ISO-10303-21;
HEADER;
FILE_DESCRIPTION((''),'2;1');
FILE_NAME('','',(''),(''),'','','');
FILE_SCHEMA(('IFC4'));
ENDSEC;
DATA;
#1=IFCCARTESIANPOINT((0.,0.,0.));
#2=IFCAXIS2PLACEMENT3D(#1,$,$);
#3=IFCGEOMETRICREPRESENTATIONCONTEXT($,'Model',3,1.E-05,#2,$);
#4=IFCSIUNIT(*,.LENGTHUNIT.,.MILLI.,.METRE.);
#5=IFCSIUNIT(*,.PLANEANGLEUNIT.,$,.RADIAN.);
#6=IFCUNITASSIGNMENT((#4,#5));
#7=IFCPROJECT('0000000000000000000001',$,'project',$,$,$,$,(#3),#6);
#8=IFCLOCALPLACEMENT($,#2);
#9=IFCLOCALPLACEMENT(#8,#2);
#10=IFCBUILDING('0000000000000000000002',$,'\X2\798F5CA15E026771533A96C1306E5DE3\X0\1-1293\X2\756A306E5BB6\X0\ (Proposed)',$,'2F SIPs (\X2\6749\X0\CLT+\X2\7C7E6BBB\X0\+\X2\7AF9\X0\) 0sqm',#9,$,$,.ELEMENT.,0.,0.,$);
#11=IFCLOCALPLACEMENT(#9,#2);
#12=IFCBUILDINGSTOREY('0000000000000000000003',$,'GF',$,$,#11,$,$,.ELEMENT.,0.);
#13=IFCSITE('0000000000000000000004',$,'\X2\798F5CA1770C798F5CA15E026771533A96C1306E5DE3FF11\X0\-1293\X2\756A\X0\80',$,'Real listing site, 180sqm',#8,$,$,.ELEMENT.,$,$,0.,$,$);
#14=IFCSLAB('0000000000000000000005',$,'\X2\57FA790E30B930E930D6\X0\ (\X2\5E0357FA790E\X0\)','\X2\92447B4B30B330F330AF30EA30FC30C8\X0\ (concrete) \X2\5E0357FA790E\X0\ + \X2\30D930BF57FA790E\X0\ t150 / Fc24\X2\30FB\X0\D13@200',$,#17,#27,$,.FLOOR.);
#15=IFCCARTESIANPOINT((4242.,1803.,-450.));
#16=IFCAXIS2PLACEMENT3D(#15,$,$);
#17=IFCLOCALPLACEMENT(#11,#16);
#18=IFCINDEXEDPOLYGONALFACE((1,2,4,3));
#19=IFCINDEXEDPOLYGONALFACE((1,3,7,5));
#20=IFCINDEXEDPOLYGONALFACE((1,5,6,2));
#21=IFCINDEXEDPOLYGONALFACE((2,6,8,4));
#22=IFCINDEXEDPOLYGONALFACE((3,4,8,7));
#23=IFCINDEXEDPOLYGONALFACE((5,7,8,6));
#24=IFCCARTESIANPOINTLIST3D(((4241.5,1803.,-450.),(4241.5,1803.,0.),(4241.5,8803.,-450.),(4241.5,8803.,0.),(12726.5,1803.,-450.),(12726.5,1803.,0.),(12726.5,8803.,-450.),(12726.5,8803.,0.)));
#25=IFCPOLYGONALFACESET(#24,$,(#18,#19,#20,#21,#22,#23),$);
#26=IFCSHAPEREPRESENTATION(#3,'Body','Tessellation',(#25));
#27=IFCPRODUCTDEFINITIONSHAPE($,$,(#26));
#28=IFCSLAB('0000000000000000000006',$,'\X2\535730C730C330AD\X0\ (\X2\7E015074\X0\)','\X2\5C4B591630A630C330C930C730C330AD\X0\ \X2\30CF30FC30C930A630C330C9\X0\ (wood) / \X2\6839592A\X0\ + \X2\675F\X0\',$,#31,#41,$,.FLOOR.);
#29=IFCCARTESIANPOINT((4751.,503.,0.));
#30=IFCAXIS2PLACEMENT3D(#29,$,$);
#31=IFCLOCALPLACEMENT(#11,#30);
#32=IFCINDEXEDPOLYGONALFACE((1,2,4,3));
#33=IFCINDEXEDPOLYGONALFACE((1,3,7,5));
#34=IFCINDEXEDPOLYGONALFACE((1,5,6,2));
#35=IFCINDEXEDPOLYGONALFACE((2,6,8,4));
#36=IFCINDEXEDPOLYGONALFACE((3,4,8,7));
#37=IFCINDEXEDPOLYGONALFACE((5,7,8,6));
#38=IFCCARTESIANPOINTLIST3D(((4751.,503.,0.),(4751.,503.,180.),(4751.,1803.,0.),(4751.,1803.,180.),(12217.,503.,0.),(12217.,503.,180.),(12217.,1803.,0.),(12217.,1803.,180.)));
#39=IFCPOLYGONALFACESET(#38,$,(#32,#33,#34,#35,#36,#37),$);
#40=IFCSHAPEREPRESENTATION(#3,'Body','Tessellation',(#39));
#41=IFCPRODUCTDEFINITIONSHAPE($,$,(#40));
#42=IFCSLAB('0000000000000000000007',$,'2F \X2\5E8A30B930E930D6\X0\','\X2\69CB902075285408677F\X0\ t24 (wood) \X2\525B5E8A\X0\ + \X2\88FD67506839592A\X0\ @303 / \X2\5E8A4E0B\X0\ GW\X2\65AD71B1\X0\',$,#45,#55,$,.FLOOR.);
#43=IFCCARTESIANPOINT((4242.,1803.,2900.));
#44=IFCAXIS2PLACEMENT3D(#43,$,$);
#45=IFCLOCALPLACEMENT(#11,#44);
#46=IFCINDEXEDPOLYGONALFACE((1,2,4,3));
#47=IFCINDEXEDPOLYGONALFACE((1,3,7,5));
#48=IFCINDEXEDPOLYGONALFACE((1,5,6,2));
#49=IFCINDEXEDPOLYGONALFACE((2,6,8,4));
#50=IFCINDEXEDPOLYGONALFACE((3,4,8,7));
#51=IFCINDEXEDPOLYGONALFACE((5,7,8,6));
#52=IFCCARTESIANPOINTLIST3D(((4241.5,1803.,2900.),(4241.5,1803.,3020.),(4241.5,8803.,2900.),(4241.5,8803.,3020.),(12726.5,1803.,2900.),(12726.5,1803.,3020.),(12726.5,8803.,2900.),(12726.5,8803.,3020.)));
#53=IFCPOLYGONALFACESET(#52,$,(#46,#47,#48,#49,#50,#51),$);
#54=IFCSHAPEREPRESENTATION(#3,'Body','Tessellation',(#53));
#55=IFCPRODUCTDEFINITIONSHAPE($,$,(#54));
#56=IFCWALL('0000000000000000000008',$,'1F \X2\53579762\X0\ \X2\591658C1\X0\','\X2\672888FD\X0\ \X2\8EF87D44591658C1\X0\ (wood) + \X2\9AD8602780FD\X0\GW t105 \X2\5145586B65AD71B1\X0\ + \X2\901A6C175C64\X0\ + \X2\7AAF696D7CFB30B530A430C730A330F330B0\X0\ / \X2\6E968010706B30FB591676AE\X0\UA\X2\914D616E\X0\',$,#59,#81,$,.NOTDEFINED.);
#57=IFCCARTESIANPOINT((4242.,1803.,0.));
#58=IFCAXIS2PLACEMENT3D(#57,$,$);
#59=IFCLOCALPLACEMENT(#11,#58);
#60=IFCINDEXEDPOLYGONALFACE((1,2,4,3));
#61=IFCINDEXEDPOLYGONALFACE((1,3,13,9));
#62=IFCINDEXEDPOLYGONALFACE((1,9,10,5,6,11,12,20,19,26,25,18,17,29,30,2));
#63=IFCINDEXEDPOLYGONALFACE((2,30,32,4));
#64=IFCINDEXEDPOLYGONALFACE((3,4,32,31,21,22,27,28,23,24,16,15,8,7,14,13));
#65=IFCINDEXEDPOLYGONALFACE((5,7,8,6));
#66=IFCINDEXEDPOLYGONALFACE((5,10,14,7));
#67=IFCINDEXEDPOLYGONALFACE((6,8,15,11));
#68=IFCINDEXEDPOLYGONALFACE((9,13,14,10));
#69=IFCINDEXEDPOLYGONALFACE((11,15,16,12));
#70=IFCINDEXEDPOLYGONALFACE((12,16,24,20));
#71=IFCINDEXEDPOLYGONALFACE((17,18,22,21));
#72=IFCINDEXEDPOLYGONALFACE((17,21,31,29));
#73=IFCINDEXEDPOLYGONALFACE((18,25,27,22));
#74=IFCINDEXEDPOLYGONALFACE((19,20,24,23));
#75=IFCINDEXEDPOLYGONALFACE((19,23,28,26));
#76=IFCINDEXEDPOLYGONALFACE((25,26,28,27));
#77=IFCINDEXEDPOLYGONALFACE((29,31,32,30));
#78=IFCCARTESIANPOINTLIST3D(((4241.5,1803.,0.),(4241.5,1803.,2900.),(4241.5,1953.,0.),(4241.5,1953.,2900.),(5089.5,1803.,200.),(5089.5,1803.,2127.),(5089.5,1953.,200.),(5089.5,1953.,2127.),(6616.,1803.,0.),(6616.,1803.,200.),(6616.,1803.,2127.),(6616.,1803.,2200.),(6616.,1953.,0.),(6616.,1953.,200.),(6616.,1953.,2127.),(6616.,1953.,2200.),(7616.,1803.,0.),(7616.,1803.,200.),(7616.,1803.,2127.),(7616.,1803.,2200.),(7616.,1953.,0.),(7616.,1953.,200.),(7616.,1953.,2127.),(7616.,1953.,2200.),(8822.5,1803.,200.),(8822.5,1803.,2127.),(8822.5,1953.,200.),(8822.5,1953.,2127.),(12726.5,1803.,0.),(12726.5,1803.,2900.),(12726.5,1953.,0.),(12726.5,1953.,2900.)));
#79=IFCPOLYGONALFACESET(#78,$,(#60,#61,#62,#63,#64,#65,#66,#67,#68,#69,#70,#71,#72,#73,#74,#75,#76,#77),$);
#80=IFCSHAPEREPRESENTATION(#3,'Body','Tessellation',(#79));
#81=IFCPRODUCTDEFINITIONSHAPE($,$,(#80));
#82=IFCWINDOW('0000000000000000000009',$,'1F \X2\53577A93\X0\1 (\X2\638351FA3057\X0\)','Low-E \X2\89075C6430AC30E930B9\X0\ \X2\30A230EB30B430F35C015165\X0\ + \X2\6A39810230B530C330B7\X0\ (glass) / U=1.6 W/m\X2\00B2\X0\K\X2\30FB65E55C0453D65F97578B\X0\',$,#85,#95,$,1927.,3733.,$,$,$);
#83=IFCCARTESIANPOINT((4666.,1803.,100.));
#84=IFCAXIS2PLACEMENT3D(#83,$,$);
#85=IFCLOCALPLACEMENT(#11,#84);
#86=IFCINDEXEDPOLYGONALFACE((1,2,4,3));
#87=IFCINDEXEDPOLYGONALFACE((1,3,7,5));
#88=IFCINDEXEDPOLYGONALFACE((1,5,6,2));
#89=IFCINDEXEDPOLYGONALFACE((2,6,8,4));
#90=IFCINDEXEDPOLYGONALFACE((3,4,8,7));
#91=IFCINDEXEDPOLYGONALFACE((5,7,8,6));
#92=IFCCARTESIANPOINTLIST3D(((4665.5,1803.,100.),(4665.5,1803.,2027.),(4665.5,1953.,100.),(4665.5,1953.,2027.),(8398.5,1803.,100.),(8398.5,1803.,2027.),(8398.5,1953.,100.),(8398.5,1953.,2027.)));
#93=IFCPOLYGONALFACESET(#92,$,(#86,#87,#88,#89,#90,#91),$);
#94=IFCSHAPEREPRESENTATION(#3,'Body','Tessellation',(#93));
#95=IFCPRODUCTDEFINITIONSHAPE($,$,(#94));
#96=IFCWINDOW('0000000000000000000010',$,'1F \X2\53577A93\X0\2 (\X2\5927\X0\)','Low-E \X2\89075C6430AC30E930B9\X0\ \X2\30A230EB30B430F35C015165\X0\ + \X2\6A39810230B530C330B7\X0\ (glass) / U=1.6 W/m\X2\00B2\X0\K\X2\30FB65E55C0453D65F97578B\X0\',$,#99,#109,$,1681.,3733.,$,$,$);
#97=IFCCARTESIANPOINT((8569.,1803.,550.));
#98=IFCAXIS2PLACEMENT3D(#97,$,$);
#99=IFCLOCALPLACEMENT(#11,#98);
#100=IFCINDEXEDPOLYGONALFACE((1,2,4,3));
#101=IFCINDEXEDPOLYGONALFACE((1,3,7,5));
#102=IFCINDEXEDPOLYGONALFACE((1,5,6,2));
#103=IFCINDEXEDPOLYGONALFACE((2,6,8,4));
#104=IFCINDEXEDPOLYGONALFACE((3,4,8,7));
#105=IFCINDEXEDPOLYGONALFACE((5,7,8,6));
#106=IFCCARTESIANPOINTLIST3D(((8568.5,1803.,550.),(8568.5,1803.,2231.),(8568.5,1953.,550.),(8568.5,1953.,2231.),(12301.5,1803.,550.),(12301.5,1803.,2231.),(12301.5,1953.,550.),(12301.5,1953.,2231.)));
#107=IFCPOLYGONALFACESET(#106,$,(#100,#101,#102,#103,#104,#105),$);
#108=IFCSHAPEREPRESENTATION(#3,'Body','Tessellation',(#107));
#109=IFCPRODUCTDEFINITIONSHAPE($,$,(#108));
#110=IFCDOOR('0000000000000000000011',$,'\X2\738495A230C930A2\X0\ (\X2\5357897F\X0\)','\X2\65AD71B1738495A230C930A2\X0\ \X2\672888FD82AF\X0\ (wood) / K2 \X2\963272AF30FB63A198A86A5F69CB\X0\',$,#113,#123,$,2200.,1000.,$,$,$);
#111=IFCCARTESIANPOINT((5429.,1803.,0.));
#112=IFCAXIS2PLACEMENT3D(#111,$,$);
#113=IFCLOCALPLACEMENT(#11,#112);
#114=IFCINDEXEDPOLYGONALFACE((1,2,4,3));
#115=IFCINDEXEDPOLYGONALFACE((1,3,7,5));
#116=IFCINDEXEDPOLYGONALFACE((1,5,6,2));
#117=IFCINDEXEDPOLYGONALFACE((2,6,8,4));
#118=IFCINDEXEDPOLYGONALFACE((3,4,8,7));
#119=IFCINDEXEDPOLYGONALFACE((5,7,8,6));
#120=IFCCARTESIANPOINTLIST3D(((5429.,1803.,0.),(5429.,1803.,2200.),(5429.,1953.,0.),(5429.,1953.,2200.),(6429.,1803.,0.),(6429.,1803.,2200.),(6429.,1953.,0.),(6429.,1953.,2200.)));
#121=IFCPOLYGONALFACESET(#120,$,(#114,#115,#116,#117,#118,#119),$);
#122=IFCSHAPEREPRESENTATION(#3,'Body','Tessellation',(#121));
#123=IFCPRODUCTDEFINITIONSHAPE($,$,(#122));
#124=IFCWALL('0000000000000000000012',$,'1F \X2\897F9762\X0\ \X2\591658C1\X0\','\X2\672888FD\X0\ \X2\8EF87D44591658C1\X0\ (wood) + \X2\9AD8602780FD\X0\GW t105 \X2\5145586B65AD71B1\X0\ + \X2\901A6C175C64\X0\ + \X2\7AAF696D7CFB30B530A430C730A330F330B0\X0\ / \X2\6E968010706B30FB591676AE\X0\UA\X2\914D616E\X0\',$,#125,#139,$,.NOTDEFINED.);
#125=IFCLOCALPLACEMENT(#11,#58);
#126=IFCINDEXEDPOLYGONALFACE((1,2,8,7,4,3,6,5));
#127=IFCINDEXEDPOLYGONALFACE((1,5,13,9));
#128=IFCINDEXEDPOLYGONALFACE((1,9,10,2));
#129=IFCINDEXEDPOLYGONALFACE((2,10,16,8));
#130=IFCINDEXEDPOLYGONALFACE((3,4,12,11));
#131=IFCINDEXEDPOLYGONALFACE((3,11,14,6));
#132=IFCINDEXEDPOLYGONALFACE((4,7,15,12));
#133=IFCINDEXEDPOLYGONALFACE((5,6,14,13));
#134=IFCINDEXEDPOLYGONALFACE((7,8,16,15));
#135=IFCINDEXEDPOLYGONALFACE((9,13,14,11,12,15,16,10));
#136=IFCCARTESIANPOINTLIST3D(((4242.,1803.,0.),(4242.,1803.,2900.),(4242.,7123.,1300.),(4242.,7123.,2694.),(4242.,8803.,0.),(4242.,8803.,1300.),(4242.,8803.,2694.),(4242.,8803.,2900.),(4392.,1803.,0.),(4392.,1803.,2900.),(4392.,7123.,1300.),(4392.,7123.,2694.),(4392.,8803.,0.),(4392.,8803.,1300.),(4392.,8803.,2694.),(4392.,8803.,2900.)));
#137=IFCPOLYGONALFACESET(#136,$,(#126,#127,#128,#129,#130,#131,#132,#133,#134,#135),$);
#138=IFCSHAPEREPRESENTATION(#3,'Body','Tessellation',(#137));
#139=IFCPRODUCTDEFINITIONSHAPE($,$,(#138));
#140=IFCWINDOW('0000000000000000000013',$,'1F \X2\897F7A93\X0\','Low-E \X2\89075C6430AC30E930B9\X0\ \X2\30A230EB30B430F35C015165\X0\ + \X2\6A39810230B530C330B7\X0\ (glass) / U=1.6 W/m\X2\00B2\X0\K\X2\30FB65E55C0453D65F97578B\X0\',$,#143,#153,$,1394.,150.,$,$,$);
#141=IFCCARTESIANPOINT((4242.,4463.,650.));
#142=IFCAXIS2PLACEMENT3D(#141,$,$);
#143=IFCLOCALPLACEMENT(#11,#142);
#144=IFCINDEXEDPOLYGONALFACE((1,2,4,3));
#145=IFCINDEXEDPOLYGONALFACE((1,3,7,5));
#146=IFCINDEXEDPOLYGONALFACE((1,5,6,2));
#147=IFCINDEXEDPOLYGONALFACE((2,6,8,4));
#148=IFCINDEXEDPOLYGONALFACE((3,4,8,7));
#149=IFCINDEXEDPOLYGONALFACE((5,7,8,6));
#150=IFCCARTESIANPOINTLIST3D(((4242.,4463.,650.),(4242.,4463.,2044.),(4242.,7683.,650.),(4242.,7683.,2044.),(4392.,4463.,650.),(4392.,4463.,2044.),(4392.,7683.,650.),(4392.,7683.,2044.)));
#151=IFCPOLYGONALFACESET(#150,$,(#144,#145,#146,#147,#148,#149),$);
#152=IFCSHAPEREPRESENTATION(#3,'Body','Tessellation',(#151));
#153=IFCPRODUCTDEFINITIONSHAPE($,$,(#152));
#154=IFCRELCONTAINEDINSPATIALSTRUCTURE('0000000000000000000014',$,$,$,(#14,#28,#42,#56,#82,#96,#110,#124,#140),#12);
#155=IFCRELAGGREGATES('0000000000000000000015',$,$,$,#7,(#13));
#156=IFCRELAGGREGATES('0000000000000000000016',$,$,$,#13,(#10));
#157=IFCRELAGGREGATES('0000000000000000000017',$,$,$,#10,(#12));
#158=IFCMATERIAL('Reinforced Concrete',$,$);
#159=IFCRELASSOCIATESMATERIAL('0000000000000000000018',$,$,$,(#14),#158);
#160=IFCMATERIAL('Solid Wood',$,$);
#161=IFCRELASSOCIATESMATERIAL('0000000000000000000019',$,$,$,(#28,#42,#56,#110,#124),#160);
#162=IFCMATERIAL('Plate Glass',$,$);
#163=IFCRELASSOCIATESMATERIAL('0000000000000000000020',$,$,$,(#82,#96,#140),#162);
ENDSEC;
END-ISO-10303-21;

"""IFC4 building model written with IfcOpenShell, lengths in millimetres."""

from ifc_helpers import new_model, si_unit, frame, frame_2d, origin, place, context, project, spatial, rectangle, extrude, material, element, fill, save


model = new_model("IFC4")

# Units and contexts
model_context = context("Model", 3, precision=1e-05, world=origin())
ifc_project = project(units=[si_unit("LENGTHUNIT", "METRE", prefix="MILLI"), si_unit("PLANEANGLEUNIT", "RADIAN")], contexts=[model_context])

# Site, building, storey
site_placement = place(None, origin())
site = spatial("IfcSite", under=ifc_project, at=site_placement, Name="福岡県福岡市東区雁の巣１-1293番80", ObjectType="Real listing site, 180sqm", CompositionType="ELEMENT", RefElevation=0.0)
building_placement = place(site_placement, origin())
building = spatial("IfcBuilding", under=site, at=building_placement, Name="福岡市東区雁の巣1-1293番の家 (Proposed)", ObjectType="2F SIPs (杉CLT+籾殻+竹) 0sqm", CompositionType="ELEMENT", ElevationOfRefHeight=0.0, ElevationOfTerrain=0.0)
storey_placement = place(building_placement, origin())
storey = spatial("IfcBuildingStorey", under=building, at=storey_placement, Name="GF", CompositionType="ELEMENT", Elevation=0.0)

# Slabs
ifc_material_1 = material(Name="Reinforced Concrete")
slab_1_placement = place(storey_placement, frame((4242.0, 1803.0, -450.0)))
element("IfcSlab", 1, at=slab_1_placement, inside=storey, material=ifc_material_1, Name="基礎スラブ (布基礎)", Description="鉄筋コンクリート (concrete) 布基礎 + ベタ基礎 t150 / Fc24・D13@200", PredefinedType="FLOOR", context=model_context, shape_type="SweptSolid", body=[
    extrude(rectangle(XDim=8485.0, YDim=7000.0, at=frame_2d((4242.0, 3500.0))), frame((4242.0, 1803.0, -450.0)), (0.0, 0.0, 1.0), 450.0),
])
ifc_material_2 = material(Name="Solid Wood")
slab_2_placement = place(storey_placement, frame((4751.0, 503.0, 0.0)))
element("IfcSlab", 2, at=slab_2_placement, inside=storey, material=ifc_material_2, Name="南デッキ (縁側)", Description="屋外ウッドデッキ ハードウッド (wood) / 根太 + 束", PredefinedType="FLOOR", context=model_context, shape_type="SweptSolid", body=[
    extrude(rectangle(XDim=7466.0, YDim=1300.0, at=frame_2d((3733.0, 650.0))), frame((4751.0, 503.0, 0.0)), (0.0, 0.0, 1.0), 180.0),
])
slab_3_placement = place(storey_placement, frame((4242.0, 1803.0, 2900.0)))
element("IfcSlab", 3, at=slab_3_placement, inside=storey, material=ifc_material_2, Name="2F 床スラブ", Description="構造用合板 t24 (wood) 剛床 + 製材根太 @303 / 床下 GW断熱", PredefinedType="FLOOR", context=model_context, shape_type="SweptSolid", body=[
    extrude(rectangle(XDim=8485.0, YDim=7000.0, at=frame_2d((4242.0, 3500.0))), frame((4242.0, 1803.0, 2900.0)), (0.0, 0.0, 1.0), 120.0),
])

# Wall, openings, windows, door
wall_1_placement = place(storey_placement, frame((4242.0, 1803.0, 0.0)))
wall_1 = element("IfcWall", 4, at=wall_1_placement, inside=storey, material=ifc_material_2, Name="1F 南面 外壁", Description="木製 軸組外壁 (wood) + 高性能GW t105 充填断熱 + 通気層 + 窯業系サイディング / 準耐火・外皮UA配慮", PredefinedType="NOTDEFINED", context=model_context, shape_type="SweptSolid", body=[
    extrude(rectangle(XDim=8485.0, YDim=150.0, at=frame_2d((4242.0, 75.0))), frame((4242.0, 1803.0, 0.0)), (0.0, 0.0, 1.0), 2900.0),
])
opening_1_placement = place(storey_placement, frame((4666.0, 1803.0, 100.0)))
opening_1 = element("IfcOpeningElement", 5, at=opening_1_placement, cuts=wall_1, PredefinedType="NOTDEFINED", context=model_context, shape_type="SweptSolid", body=[
    extrude(rectangle(XDim=3733.0, YDim=150.0, at=frame_2d((1866.0, 75.0))), frame((4666.0, 1803.0, 100.0)), (0.0, 0.0, 1.0), 1927.0),
])
opening_2_placement = place(storey_placement, frame((8569.0, 1803.0, 550.0)))
opening_2 = element("IfcOpeningElement", 6, at=opening_2_placement, cuts=wall_1, PredefinedType="NOTDEFINED", context=model_context, shape_type="SweptSolid", body=[
    extrude(rectangle(XDim=3733.0, YDim=150.0, at=frame_2d((1866.0, 75.0))), frame((8569.0, 1803.0, 550.0)), (0.0, 0.0, 1.0), 1681.0),
])
opening_3_placement = place(storey_placement, frame((5429.0, 1803.0, 0.0)))
opening_3 = element("IfcOpeningElement", 7, at=opening_3_placement, cuts=wall_1, PredefinedType="NOTDEFINED", context=model_context, shape_type="SweptSolid", body=[
    extrude(rectangle(XDim=1000.0, YDim=150.0, at=frame_2d((500.0, 75.0))), frame((5429.0, 1803.0, 0.0)), (0.0, 0.0, 1.0), 2200.0),
])
ifc_material_3 = material(Name="Plate Glass")
window_1_placement = place(storey_placement, frame((4666.0, 1803.0, 100.0)))
window_1 = element("IfcWindow", 8, at=window_1_placement, inside=storey, material=ifc_material_3, Name="1F 南窓1 (掃出し)", Description="Low-E 複層ガラス アルゴン封入 + 樹脂サッシ (glass) / U=1.6 W/m²K・日射取得型", OverallHeight=1927.0, OverallWidth=3733.0, context=model_context, shape_type="SweptSolid", body=[
    extrude(rectangle(XDim=3733.0, YDim=150.0, at=frame_2d((1866.0, 75.0))), frame((4666.0, 1803.0, 100.0)), (0.0, 0.0, 1.0), 1927.0),
])
fill(opening_1, window_1)
window_2_placement = place(storey_placement, frame((8569.0, 1803.0, 550.0)))
window_2 = element("IfcWindow", 9, at=window_2_placement, inside=storey, material=ifc_material_3, Name="1F 南窓2 (大)", Description="Low-E 複層ガラス アルゴン封入 + 樹脂サッシ (glass) / U=1.6 W/m²K・日射取得型", OverallHeight=1681.0, OverallWidth=3733.0, context=model_context, shape_type="SweptSolid", body=[
    extrude(rectangle(XDim=3733.0, YDim=150.0, at=frame_2d((1866.0, 75.0))), frame((8569.0, 1803.0, 550.0)), (0.0, 0.0, 1.0), 1681.0),
])
fill(opening_2, window_2)
door_placement = place(storey_placement, frame((5429.0, 1803.0, 0.0)))
door = element("IfcDoor", 10, at=door_placement, inside=storey, material=ifc_material_2, Name="玄関ドア (南西)", Description="断熱玄関ドア 木製芯 (wood) / K2 防犯・採風機構", OverallHeight=2200.0, OverallWidth=1000.0, context=model_context, shape_type="SweptSolid", body=[
    extrude(rectangle(XDim=1000.0, YDim=150.0, at=frame_2d((500.0, 75.0))), frame((5429.0, 1803.0, 0.0)), (0.0, 0.0, 1.0), 2200.0),
])
fill(opening_3, door)

# Wall, opening, window
wall_2_placement = place(storey_placement, frame((4242.0, 1803.0, 0.0)))
wall_2 = element("IfcWall", 11, at=wall_2_placement, inside=storey, material=ifc_material_2, Name="1F 西面 外壁", Description="木製 軸組外壁 (wood) + 高性能GW t105 充填断熱 + 通気層 + 窯業系サイディング / 準耐火・外皮UA配慮", PredefinedType="NOTDEFINED", context=model_context, shape_type="SweptSolid", body=[
    extrude(rectangle(XDim=150.0, YDim=7000.0, at=frame_2d((75.0, 3500.0))), frame((4242.0, 1803.0, 0.0)), (0.0, 0.0, 1.0), 2900.0),
])
opening_4_placement = place(storey_placement, frame((4242.0, 4463.0, 650.0)))
opening_4 = element("IfcOpeningElement", 12, at=opening_4_placement, cuts=wall_2, PredefinedType="NOTDEFINED", context=model_context, shape_type="SweptSolid", body=[
    extrude(rectangle(XDim=150.0, YDim=3220.0, at=frame_2d((75.0, 1610.0))), frame((4242.0, 4463.0, 650.0)), (0.0, 0.0, 1.0), 1394.0),
])
window_3_placement = place(storey_placement, frame((4242.0, 4463.0, 650.0)))
window_3 = element("IfcWindow", 13, at=window_3_placement, inside=storey, material=ifc_material_3, Name="1F 西窓", Description="Low-E 複層ガラス アルゴン封入 + 樹脂サッシ (glass) / U=1.6 W/m²K・日射取得型", OverallHeight=1394.0, OverallWidth=150.0, context=model_context, shape_type="SweptSolid", body=[
    extrude(rectangle(XDim=150.0, YDim=3220.0, at=frame_2d((75.0, 1610.0))), frame((4242.0, 4463.0, 650.0)), (0.0, 0.0, 1.0), 1394.0),
])
fill(opening_4, window_3)

save(model, "model.ifc")
